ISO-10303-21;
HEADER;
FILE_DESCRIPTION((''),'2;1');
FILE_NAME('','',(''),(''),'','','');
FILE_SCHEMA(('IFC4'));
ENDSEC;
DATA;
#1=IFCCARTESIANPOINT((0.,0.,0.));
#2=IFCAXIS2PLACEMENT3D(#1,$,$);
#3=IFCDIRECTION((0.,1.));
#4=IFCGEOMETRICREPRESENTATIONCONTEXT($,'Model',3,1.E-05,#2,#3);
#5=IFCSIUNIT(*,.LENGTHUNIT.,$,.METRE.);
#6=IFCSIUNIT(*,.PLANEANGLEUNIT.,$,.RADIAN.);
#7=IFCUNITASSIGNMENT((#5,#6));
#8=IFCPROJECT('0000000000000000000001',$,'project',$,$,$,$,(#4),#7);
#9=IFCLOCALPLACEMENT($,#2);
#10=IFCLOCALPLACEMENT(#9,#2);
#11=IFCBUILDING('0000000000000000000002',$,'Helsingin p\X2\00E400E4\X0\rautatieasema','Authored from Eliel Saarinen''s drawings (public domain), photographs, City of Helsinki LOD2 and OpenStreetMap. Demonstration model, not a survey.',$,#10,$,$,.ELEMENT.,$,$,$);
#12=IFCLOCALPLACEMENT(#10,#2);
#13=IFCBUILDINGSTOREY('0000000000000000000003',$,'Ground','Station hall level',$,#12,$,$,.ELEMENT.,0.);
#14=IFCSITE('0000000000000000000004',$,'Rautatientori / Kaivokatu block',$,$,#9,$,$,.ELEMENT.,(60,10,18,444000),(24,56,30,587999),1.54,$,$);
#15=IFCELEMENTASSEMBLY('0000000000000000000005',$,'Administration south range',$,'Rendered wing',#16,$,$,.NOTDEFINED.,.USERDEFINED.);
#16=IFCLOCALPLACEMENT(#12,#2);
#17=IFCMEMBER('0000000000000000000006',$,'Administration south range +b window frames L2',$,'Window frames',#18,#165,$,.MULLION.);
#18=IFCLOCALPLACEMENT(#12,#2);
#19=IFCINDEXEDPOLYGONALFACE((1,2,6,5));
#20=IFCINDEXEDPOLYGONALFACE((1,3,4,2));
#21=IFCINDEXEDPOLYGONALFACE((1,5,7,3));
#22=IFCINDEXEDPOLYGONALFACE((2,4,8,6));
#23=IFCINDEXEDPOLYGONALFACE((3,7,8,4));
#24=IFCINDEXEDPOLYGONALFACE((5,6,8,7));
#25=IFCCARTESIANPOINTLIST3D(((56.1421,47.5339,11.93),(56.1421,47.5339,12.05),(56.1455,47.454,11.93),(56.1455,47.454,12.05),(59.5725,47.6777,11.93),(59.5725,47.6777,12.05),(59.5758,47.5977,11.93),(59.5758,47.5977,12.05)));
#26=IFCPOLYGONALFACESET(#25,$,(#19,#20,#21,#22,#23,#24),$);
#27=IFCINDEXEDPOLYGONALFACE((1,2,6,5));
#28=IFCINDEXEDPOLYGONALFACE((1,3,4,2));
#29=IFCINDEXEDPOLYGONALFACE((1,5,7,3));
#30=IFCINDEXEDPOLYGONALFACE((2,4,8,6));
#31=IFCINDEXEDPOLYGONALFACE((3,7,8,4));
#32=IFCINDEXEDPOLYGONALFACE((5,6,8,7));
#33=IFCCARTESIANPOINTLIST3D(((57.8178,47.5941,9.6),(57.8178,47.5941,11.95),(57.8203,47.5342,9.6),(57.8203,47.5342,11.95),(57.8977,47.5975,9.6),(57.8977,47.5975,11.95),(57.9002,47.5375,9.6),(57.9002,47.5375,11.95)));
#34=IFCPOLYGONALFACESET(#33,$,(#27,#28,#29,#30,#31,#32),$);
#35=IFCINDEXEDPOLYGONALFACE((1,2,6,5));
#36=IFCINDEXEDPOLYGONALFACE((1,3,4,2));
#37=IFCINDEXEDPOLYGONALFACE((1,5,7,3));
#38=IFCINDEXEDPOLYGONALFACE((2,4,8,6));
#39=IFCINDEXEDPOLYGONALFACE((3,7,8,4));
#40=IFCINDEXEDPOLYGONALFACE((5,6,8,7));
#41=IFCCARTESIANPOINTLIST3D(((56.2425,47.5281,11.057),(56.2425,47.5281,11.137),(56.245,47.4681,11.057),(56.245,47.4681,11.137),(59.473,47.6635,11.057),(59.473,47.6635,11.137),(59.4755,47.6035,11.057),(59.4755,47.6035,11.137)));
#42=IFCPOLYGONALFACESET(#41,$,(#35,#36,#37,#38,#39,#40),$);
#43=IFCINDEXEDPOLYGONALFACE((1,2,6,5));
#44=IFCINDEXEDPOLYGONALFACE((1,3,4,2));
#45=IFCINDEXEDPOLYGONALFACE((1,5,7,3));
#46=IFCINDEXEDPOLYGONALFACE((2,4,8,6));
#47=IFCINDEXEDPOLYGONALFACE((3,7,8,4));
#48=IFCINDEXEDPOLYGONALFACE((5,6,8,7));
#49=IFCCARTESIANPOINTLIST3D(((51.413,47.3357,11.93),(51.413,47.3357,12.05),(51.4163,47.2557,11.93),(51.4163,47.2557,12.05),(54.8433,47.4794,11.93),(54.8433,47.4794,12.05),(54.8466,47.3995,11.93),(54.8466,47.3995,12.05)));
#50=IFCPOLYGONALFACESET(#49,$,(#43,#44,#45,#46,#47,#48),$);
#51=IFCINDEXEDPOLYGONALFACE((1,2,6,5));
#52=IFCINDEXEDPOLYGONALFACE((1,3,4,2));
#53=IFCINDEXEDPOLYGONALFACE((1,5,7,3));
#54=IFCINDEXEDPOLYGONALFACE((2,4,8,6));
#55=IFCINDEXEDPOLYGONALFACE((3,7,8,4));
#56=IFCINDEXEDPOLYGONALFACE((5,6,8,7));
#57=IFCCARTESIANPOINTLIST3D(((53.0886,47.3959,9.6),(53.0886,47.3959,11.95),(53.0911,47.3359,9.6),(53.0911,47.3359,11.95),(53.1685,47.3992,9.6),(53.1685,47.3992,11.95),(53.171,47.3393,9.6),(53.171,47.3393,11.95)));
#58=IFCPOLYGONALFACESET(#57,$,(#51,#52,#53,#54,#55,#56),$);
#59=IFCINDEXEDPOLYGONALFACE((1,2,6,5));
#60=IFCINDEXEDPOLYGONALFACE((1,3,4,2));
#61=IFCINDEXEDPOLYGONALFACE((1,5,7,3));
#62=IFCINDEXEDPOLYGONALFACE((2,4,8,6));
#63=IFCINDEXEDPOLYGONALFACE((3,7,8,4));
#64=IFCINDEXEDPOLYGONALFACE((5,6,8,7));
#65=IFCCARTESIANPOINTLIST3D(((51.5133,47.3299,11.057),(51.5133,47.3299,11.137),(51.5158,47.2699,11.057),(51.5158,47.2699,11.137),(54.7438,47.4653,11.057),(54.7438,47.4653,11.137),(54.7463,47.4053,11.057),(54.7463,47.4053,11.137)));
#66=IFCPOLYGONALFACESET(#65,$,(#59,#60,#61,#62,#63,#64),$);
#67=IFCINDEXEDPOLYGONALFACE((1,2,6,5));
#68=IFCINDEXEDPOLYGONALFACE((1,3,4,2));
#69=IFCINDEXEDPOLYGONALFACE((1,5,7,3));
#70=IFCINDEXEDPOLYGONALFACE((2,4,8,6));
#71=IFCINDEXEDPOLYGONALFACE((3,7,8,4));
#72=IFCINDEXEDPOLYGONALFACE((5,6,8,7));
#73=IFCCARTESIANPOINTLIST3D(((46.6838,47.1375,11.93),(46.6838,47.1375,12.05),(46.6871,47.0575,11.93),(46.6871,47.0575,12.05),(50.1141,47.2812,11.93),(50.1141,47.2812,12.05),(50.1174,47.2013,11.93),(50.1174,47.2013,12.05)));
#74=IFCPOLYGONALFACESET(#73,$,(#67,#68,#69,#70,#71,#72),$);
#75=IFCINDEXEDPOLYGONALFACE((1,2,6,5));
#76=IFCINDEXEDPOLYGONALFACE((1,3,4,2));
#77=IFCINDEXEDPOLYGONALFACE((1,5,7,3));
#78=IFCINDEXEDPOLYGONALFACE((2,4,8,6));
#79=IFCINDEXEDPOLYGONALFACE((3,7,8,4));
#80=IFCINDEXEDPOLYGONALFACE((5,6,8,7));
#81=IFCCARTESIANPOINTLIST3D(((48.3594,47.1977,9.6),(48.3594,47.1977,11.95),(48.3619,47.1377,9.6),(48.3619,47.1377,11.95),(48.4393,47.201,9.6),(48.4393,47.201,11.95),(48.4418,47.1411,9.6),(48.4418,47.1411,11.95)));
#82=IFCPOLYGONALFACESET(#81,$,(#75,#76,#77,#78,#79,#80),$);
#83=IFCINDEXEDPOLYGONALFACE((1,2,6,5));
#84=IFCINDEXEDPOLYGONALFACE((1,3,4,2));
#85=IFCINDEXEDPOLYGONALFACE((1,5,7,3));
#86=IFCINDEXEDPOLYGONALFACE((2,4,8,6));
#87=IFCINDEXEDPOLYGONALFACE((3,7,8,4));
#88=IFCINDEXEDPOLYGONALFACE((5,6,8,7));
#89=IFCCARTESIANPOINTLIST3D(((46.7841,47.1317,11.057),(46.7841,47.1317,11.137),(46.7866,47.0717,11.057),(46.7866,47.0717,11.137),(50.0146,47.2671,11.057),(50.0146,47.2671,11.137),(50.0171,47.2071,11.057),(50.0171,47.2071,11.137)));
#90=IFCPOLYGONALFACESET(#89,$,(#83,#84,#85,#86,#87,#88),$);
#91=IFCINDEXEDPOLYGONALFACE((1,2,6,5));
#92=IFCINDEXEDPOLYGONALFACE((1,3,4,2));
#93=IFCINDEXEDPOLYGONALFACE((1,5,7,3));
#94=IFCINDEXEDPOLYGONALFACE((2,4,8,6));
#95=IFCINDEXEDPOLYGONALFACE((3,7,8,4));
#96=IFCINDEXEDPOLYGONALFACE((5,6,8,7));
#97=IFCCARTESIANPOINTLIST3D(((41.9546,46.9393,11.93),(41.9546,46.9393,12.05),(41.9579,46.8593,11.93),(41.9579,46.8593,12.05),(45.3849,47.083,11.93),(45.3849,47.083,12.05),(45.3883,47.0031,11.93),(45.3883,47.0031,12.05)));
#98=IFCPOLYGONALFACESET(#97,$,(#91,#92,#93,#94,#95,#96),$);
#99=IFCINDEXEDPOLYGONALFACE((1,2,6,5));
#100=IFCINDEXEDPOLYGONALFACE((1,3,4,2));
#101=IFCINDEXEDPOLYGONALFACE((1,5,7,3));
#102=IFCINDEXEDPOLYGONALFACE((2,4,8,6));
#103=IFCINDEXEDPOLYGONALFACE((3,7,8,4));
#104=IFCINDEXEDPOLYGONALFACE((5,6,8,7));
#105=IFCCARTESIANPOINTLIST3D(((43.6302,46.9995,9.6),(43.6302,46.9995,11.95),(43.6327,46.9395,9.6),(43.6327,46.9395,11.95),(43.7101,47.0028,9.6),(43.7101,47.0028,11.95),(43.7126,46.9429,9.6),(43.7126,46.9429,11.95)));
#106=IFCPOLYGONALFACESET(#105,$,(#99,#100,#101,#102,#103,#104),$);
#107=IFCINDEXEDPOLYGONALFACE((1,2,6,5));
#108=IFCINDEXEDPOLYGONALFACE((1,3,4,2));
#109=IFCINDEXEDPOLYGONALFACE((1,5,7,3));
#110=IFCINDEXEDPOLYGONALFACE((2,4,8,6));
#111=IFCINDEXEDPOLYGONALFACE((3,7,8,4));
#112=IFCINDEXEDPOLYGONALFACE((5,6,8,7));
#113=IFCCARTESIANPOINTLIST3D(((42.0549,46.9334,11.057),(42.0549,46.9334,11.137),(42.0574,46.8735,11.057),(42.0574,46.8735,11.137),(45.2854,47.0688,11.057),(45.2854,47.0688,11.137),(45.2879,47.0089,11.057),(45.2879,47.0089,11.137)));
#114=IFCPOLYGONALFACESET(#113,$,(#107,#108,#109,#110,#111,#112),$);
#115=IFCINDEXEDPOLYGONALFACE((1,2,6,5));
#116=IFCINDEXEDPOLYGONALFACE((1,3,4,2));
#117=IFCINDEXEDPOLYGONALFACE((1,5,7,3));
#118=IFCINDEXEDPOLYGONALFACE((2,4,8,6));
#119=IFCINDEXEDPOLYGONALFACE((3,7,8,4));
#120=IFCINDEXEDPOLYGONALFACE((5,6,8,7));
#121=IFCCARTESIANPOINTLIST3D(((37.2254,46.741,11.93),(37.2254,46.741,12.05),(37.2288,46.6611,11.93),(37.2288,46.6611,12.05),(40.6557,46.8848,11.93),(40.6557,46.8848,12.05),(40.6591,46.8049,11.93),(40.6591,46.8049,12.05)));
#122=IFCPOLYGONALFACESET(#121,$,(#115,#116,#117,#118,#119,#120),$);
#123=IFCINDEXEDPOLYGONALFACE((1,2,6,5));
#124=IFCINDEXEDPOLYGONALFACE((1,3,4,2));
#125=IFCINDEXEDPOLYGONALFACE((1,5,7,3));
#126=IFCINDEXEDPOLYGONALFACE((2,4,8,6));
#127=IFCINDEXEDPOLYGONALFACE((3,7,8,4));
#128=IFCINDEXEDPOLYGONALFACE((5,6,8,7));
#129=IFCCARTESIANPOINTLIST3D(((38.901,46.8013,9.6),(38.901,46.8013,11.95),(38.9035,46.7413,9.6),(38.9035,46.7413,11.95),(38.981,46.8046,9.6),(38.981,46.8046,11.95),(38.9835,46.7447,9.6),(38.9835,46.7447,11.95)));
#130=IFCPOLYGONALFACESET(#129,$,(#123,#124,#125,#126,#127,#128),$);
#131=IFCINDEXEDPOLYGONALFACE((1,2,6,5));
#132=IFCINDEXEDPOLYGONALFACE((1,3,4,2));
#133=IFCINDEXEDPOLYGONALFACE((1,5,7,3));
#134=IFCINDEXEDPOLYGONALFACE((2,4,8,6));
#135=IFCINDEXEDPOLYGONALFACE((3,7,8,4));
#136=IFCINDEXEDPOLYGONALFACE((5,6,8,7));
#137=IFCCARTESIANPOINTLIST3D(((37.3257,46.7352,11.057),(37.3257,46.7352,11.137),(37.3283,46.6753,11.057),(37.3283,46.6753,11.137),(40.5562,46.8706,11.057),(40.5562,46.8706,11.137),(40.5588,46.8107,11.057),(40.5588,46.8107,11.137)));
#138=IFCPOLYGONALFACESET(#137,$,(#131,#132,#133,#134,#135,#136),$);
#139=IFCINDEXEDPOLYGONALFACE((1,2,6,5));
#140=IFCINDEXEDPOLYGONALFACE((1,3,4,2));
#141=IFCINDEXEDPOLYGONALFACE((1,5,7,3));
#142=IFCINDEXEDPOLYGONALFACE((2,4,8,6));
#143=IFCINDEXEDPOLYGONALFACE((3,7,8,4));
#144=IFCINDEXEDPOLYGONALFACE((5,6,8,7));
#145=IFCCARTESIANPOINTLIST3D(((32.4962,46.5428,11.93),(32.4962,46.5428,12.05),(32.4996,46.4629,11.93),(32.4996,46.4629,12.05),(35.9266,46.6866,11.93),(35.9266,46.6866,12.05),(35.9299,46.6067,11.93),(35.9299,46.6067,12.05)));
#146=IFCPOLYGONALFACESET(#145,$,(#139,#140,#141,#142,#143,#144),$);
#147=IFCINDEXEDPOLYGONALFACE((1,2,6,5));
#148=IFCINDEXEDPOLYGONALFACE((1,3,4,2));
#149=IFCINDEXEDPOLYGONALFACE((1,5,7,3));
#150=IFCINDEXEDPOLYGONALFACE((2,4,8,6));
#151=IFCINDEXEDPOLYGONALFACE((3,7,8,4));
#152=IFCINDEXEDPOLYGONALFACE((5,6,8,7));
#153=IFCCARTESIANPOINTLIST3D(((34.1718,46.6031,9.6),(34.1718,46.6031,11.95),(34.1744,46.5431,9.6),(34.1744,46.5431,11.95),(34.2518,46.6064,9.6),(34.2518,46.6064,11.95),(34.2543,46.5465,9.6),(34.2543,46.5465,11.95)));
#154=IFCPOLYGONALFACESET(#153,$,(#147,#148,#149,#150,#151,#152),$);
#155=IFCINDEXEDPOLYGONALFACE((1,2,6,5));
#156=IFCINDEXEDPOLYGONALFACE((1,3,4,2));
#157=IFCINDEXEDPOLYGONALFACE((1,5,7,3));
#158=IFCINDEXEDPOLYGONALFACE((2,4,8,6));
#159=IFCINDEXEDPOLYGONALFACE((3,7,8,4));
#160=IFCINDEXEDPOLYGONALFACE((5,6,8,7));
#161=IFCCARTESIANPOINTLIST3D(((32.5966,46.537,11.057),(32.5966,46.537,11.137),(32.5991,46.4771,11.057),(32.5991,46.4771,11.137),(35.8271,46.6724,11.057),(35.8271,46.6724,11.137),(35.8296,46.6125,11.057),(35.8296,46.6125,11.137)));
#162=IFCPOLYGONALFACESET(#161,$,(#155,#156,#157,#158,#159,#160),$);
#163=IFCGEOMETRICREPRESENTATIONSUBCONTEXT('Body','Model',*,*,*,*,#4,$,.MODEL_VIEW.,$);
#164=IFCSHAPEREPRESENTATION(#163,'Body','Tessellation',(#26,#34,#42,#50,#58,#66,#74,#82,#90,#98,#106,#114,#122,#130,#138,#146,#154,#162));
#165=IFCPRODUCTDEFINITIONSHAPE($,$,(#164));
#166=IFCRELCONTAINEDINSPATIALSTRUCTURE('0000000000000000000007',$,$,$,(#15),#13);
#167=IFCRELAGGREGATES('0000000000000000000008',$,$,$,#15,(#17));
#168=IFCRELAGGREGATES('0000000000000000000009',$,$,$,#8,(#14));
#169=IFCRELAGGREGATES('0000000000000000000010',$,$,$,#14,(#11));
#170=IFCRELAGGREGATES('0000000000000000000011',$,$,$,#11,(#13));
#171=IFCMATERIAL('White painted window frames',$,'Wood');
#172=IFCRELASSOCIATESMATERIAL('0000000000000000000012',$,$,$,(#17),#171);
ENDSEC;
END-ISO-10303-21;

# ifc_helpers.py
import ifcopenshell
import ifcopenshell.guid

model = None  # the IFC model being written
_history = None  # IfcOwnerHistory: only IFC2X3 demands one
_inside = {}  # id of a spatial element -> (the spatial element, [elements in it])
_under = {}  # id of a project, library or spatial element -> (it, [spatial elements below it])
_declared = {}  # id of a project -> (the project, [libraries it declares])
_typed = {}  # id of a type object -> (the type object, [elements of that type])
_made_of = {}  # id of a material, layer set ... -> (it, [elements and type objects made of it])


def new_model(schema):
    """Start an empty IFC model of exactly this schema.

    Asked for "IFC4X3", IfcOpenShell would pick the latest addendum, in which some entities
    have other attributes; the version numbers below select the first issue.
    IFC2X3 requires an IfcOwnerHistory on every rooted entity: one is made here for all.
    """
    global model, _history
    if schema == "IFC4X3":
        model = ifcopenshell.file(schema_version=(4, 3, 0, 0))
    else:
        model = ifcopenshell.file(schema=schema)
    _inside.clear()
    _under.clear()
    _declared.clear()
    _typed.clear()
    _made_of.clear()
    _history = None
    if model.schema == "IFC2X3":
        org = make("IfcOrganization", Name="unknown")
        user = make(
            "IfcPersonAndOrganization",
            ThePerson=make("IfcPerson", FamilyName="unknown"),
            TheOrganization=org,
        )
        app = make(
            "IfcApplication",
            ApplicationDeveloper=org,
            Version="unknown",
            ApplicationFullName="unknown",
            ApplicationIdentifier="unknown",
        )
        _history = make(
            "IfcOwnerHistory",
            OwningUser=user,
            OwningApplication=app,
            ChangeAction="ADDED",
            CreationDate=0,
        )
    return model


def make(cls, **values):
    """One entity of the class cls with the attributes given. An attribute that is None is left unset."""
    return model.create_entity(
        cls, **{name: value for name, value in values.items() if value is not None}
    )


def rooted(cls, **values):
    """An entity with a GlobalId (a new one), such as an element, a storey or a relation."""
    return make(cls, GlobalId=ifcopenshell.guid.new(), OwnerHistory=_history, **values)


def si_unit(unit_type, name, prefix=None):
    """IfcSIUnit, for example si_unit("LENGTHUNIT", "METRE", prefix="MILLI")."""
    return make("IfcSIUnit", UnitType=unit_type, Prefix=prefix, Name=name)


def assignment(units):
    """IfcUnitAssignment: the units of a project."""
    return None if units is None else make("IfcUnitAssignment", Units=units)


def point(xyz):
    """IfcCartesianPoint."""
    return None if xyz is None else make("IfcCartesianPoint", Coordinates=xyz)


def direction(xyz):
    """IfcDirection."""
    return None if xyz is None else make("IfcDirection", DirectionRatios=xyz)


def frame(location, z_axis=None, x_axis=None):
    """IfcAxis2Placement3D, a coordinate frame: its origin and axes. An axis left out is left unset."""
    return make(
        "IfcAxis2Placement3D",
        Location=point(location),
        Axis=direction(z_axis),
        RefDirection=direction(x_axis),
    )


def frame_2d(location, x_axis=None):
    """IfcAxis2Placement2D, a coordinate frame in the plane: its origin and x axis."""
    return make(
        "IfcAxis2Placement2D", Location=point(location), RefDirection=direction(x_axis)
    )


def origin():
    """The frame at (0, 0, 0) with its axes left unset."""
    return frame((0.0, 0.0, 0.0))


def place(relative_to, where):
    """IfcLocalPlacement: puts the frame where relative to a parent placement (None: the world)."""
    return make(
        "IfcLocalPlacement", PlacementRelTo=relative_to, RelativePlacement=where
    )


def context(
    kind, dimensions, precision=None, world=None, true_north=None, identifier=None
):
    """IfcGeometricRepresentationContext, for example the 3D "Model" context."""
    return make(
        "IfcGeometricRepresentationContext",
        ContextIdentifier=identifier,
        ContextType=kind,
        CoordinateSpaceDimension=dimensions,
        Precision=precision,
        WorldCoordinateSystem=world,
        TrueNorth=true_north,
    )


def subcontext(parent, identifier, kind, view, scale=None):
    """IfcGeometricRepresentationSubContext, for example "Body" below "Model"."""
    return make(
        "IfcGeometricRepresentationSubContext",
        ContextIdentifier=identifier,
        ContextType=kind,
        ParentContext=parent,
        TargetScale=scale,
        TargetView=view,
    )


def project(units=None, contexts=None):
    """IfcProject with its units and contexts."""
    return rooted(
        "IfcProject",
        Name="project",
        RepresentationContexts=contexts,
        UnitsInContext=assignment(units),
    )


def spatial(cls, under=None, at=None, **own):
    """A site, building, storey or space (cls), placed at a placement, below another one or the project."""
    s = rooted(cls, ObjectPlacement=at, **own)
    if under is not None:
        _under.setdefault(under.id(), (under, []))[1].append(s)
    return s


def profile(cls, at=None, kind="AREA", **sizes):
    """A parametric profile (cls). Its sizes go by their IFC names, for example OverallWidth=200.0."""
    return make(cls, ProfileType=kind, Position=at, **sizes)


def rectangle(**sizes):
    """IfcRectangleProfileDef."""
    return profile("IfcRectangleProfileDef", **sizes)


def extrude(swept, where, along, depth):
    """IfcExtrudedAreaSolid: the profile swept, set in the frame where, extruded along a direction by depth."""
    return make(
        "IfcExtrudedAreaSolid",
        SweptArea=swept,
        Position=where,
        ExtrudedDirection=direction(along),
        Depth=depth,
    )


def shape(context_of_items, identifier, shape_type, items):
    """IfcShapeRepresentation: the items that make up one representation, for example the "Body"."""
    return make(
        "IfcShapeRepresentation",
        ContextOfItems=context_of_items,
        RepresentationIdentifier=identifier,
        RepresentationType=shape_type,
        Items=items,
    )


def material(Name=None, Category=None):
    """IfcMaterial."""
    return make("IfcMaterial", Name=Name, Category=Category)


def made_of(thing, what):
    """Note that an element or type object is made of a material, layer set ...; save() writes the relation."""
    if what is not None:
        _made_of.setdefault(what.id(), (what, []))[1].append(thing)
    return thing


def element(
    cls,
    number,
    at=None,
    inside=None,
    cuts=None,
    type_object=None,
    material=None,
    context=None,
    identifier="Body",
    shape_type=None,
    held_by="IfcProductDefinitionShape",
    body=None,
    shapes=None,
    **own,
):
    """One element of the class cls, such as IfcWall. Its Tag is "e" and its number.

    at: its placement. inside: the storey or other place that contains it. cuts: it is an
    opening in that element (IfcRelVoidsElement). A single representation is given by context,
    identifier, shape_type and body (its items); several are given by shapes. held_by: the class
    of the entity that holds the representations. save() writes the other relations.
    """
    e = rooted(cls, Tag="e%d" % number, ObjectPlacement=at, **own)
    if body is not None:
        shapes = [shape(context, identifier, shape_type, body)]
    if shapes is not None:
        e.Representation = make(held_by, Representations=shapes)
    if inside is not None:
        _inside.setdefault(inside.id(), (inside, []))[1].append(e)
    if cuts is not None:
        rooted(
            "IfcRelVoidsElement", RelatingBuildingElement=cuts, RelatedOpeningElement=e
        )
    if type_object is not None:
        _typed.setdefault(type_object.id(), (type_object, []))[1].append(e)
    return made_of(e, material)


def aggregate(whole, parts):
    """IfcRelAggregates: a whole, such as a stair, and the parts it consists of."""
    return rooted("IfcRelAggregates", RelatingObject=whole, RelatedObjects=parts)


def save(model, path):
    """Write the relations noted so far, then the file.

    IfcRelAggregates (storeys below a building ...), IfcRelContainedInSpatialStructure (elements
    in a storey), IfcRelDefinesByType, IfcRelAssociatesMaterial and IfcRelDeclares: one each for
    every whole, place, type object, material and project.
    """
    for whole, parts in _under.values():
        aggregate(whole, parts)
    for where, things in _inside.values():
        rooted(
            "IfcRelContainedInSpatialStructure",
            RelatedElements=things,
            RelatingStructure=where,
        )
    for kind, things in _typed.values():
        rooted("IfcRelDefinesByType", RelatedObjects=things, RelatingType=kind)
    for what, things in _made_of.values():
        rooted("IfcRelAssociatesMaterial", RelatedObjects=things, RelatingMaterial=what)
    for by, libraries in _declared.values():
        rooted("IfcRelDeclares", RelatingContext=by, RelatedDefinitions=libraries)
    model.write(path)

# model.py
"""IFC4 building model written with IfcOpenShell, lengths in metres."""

from ifc_helpers import new_model, si_unit, direction, frame, frame_2d, origin, place, context, subcontext, project, spatial, rectangle, extrude, material, element, aggregate, save


model = new_model("IFC4")

# Units and contexts
model_context = context("Model", 3, precision=1e-05, world=origin(), true_north=direction((0.0, 1.0)))
body_context = subcontext(model_context, "Body", "Model", "MODEL_VIEW")
ifc_project = project(units=[si_unit("LENGTHUNIT", "METRE"), si_unit("PLANEANGLEUNIT", "RADIAN")], contexts=[model_context])

# Site, building, storey
site_placement = place(None, origin())
site = spatial("IfcSite", under=ifc_project, at=site_placement, Name="Rautatientori / Kaivokatu block", CompositionType="ELEMENT", RefLatitude=(60, 10, 18, 444000), RefLongitude=(24, 56, 30, 587999), RefElevation=1.54)
building_placement = place(site_placement, origin())
building = spatial("IfcBuilding", under=site, at=building_placement, Name="Helsingin päärautatieasema", Description="Authored from Eliel Saarinen's drawings (public domain), photographs, City of Helsinki LOD2 and OpenStreetMap. Demonstration model, not a survey.", CompositionType="ELEMENT")
storey_placement = place(building_placement, origin())
storey = spatial("IfcBuildingStorey", under=building, at=storey_placement, Name="Ground", Description="Station hall level", CompositionType="ELEMENT", Elevation=0.0)

# Element assembly, member
assembly_1_placement = place(building_placement, origin())
assembly_1 = element("IfcElementAssembly", 1, at=assembly_1_placement, inside=storey, Name="Administration south range", ObjectType="Rendered wing", AssemblyPlace="NOTDEFINED", PredefinedType="USERDEFINED")
ifc_material_1 = material(Name="White painted window frames", Category="Wood")
member_1_placement = place(building_placement, origin())
member_1 = element("IfcMember", 2, at=member_1_placement, material=ifc_material_1, Name="Administration south range +b window frames L2", ObjectType="Window frames", PredefinedType="MULLION", context=body_context, shape_type="SweptSolid", body=[
    extrude(rectangle(XDim=3.4333, YDim=0.08, at=frame_2d((0.0, 0.0), x_axis=(-0.999123, -0.041876))), frame((57.859, 47.5658, 11.93)), (0.0, 0.0, 1.0), 0.12),
    extrude(rectangle(XDim=0.08, YDim=0.06, at=frame_2d((0.0, 0.0), x_axis=(-0.999123, -0.041876))), frame((57.859, 47.5658, 9.6)), (0.0, 0.0, 1.0), 2.35),
    extrude(rectangle(XDim=3.2333, YDim=0.06, at=frame_2d((0.0, 0.0), x_axis=(-0.999123, -0.041876))), frame((57.859, 47.5658, 11.057)), (0.0, 0.0, 1.0), 0.08),
    extrude(rectangle(XDim=3.4333, YDim=0.08, at=frame_2d((0.0, 0.0), x_axis=(-0.999123, -0.041876))), frame((53.1298, 47.3676, 11.93)), (0.0, 0.0, 1.0), 0.12),
    extrude(rectangle(XDim=0.08, YDim=0.06, at=frame_2d((0.0, 0.0), x_axis=(-0.999123, -0.041876))), frame((53.1298, 47.3676, 9.6)), (0.0, 0.0, 1.0), 2.35),
    extrude(rectangle(XDim=3.2333, YDim=0.06, at=frame_2d((0.0, 0.0), x_axis=(-0.999123, -0.041876))), frame((53.1298, 47.3676, 11.057)), (0.0, 0.0, 1.0), 0.08),
    extrude(rectangle(XDim=3.4333, YDim=0.08, at=frame_2d((0.0, 0.0), x_axis=(-0.999123, -0.041876))), frame((48.4006, 47.1694, 11.93)), (0.0, 0.0, 1.0), 0.12),
    extrude(rectangle(XDim=0.08, YDim=0.06, at=frame_2d((0.0, 0.0), x_axis=(-0.999123, -0.041876))), frame((48.4006, 47.1694, 9.6)), (0.0, 0.0, 1.0), 2.35),
    extrude(rectangle(XDim=3.2333, YDim=0.06, at=frame_2d((0.0, 0.0), x_axis=(-0.999123, -0.041876))), frame((48.4006, 47.1694, 11.057)), (0.0, 0.0, 1.0), 0.08),
    extrude(rectangle(XDim=3.4333, YDim=0.08, at=frame_2d((0.0, 0.0), x_axis=(-0.999123, -0.041876))), frame((43.6714, 46.9712, 11.93)), (0.0, 0.0, 1.0), 0.12),
    extrude(rectangle(XDim=0.08, YDim=0.06, at=frame_2d((0.0, 0.0), x_axis=(-0.999123, -0.041876))), frame((43.6714, 46.9712, 9.6)), (0.0, 0.0, 1.0), 2.35),
    extrude(rectangle(XDim=3.2333, YDim=0.06, at=frame_2d((0.0, 0.0), x_axis=(-0.999123, -0.041876))), frame((43.6714, 46.9712, 11.057)), (0.0, 0.0, 1.0), 0.08),
    extrude(rectangle(XDim=3.4333, YDim=0.08, at=frame_2d((0.0, 0.0), x_axis=(-0.999123, -0.041876))), frame((38.9422, 46.773, 11.93)), (0.0, 0.0, 1.0), 0.12),
    extrude(rectangle(XDim=0.08, YDim=0.06, at=frame_2d((0.0, 0.0), x_axis=(-0.999123, -0.041876))), frame((38.9422, 46.773, 9.6)), (0.0, 0.0, 1.0), 2.35),
    extrude(rectangle(XDim=3.2333, YDim=0.06, at=frame_2d((0.0, 0.0), x_axis=(-0.999123, -0.041876))), frame((38.9422, 46.773, 11.057)), (0.0, 0.0, 1.0), 0.08),
    extrude(rectangle(XDim=3.4333, YDim=0.08, at=frame_2d((0.0, 0.0), x_axis=(-0.999123, -0.041876))), frame((34.2131, 46.5748, 11.93)), (0.0, 0.0, 1.0), 0.12),
    extrude(rectangle(XDim=0.08, YDim=0.06, at=frame_2d((0.0, 0.0), x_axis=(-0.999123, -0.041876))), frame((34.2131, 46.5748, 9.6)), (0.0, 0.0, 1.0), 2.35),
    extrude(rectangle(XDim=3.2333, YDim=0.06, at=frame_2d((0.0, 0.0), x_axis=(-0.999123, -0.041876))), frame((34.2131, 46.5748, 11.057)), (0.0, 0.0, 1.0), 0.08),
])

aggregate(assembly_1, [member_1])

save(model, "model.ifc")
